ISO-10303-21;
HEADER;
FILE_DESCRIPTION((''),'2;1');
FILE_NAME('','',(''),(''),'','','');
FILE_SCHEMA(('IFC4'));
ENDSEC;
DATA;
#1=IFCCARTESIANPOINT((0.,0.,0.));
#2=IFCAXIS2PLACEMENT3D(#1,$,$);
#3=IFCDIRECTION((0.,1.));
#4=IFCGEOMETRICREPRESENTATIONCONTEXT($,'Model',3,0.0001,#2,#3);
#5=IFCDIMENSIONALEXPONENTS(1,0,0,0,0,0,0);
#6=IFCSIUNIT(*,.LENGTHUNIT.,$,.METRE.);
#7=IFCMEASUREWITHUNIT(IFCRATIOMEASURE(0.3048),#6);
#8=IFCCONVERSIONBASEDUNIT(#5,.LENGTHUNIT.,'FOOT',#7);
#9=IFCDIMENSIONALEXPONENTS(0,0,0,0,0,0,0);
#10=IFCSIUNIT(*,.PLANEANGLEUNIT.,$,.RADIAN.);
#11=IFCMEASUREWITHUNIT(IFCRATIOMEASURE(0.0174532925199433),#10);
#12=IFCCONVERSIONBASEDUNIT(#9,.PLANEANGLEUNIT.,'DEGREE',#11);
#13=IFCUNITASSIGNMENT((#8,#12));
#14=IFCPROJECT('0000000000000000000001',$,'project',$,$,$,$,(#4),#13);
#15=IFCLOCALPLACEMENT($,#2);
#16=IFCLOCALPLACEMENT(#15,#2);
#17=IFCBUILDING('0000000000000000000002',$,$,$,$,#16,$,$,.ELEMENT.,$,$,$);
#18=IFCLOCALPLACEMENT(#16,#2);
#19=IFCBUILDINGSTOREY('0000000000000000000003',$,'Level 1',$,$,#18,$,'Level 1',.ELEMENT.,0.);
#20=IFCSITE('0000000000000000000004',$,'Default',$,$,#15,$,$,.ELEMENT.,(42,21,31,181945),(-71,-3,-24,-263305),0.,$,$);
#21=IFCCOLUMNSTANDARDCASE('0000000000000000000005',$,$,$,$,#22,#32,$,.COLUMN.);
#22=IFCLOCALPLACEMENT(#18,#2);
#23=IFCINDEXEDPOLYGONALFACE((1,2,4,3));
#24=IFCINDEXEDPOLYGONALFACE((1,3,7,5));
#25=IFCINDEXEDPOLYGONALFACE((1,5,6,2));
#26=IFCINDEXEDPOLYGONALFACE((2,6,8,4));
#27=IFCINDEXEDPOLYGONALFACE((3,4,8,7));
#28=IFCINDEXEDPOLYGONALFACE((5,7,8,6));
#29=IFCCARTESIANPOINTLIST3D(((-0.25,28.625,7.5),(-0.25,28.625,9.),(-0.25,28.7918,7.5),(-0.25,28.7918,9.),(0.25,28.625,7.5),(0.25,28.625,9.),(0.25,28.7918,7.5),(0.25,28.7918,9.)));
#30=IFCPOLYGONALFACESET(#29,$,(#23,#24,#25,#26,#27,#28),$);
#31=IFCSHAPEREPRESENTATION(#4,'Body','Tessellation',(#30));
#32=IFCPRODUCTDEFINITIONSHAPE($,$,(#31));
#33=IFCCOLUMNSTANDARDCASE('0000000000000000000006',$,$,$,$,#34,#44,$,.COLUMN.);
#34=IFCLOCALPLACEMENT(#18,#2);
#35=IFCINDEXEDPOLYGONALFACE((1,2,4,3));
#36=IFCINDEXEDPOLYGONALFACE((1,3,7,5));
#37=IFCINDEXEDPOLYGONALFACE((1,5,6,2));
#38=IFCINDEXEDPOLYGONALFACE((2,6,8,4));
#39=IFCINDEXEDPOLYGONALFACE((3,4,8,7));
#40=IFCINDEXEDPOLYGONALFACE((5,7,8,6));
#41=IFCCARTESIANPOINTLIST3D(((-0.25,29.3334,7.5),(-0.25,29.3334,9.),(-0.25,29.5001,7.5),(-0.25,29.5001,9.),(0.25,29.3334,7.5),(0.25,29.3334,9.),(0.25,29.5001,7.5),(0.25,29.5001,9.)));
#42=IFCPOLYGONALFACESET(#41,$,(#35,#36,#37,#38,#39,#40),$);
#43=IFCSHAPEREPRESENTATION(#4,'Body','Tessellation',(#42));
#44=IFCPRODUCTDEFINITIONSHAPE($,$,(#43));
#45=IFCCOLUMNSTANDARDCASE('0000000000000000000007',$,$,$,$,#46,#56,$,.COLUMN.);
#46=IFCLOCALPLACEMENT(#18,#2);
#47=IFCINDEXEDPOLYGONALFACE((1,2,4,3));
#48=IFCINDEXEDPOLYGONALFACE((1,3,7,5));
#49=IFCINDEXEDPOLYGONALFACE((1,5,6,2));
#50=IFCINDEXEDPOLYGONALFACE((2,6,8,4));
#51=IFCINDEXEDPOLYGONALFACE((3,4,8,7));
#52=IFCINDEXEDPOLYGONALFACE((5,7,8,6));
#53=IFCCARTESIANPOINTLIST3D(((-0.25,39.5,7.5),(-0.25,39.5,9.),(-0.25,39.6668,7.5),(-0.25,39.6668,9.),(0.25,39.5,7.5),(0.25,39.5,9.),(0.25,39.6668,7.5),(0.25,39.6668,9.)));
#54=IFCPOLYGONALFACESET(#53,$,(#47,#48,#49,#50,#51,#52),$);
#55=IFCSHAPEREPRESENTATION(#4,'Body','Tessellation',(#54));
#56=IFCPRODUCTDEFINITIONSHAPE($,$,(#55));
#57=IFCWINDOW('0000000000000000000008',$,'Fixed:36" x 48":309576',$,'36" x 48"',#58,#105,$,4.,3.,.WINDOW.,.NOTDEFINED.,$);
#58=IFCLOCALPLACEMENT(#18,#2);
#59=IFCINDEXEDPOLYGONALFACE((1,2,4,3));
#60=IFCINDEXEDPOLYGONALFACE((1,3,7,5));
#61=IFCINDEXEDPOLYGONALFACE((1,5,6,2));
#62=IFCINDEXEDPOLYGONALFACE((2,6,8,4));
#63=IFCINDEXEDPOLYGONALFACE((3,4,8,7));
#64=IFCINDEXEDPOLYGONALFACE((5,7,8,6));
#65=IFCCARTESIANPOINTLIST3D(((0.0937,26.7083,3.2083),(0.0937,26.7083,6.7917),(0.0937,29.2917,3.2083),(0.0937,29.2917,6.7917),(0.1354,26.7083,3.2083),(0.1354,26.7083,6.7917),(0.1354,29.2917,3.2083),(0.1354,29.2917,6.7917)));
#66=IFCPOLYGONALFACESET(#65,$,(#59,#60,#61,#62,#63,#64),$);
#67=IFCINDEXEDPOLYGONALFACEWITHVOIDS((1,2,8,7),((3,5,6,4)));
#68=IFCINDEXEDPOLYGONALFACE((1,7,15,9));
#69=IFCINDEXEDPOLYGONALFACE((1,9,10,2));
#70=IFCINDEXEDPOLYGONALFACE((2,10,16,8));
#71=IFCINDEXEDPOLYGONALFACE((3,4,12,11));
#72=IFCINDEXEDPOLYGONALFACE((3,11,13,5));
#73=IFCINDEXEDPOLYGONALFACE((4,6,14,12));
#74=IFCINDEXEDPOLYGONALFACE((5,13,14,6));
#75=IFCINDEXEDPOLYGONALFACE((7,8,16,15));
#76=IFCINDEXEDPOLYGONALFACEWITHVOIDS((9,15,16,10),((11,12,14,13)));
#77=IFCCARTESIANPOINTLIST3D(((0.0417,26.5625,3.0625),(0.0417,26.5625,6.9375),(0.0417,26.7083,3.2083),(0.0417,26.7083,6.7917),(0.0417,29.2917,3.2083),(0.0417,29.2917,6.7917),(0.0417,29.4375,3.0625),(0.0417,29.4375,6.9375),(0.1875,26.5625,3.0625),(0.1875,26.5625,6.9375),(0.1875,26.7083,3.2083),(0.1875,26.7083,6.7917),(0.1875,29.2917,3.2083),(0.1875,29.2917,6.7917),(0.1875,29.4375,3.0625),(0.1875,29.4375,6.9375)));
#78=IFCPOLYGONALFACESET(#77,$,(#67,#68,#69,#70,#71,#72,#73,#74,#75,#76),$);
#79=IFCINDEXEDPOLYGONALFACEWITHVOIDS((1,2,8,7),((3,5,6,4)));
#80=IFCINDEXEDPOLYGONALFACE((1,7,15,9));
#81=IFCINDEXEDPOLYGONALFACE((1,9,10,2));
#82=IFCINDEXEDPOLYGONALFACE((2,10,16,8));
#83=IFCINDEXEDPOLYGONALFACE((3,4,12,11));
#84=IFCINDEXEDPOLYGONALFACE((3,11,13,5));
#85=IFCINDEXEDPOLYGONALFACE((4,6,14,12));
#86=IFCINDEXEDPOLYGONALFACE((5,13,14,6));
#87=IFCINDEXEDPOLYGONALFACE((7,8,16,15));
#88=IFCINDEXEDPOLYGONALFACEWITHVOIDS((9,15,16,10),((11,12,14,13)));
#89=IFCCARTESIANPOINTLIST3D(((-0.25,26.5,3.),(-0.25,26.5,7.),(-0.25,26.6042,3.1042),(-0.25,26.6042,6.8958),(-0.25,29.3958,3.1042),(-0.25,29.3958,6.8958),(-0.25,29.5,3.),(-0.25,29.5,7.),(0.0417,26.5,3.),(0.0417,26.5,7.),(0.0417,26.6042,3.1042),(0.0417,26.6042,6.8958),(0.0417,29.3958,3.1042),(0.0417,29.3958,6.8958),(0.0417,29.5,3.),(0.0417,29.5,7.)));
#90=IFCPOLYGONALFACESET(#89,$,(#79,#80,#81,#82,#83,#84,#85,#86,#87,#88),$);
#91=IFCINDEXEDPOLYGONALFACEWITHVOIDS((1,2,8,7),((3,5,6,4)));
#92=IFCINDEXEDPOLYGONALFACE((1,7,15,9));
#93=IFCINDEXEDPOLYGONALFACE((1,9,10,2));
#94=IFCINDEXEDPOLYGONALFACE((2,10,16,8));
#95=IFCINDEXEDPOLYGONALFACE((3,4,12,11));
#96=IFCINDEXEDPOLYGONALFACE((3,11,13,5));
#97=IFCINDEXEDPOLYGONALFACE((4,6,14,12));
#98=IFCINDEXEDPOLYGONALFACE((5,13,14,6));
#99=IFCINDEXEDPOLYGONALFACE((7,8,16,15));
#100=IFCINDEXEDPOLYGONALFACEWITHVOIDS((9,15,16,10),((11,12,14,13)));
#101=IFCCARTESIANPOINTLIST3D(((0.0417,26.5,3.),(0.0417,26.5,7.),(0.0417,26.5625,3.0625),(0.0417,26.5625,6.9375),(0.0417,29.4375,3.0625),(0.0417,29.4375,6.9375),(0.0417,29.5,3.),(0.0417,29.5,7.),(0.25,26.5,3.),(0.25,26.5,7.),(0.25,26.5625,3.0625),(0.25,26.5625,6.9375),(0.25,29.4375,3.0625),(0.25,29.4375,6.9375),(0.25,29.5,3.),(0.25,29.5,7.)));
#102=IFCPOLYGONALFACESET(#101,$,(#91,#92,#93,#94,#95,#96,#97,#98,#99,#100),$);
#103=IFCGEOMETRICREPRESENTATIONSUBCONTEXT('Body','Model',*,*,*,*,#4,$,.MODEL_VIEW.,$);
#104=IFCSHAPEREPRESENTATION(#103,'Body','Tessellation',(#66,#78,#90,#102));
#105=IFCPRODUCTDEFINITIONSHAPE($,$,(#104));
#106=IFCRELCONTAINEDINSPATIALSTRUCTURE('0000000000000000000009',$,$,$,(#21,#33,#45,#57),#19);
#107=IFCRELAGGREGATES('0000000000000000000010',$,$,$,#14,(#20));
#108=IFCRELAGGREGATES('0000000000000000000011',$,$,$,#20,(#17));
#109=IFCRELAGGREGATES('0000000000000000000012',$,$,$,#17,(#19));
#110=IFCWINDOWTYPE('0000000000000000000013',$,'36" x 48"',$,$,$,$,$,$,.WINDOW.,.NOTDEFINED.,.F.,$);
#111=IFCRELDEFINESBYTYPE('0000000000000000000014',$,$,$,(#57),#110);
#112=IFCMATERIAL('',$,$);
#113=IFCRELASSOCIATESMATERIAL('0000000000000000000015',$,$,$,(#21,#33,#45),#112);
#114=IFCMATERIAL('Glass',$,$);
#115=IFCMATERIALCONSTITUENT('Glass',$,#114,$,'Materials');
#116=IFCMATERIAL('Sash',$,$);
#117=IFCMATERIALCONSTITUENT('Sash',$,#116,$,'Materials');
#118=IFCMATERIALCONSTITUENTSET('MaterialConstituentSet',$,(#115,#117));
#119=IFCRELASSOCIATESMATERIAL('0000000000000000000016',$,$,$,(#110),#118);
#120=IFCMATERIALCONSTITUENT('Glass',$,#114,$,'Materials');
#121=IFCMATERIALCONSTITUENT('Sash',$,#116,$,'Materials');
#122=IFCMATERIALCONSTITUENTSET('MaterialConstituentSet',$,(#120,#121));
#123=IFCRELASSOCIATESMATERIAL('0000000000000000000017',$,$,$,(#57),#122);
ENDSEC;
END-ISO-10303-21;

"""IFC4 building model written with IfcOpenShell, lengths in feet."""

from ifc_helpers import new_model, entity, si_unit, converted_unit, direction, frame, frame_2d, origin, place, context, subcontext, project, spatial, polyline, rectangle, outline, extrude, source, transform, mapped, material, constituent, constituent_set, type_object, type_shapes, element, save


model = new_model("IFC4")

# Units and contexts
model_context = context("Model", 3, precision=0.0001, world=origin(), true_north=direction((0.0, 1.0)))
body_context = subcontext(model_context, "Body", "Model", "MODEL_VIEW")
ifc_project = project(units=[converted_unit("LENGTHUNIT", "FOOT", entity("IfcRatioMeasure", 0.3048), si_unit("LENGTHUNIT", "METRE"), dimensions=[1, 0, 0, 0, 0, 0, 0]), converted_unit("PLANEANGLEUNIT", "DEGREE", entity("IfcRatioMeasure", 0.0174532925199433), si_unit("PLANEANGLEUNIT", "RADIAN"), dimensions=[0, 0, 0, 0, 0, 0, 0])], contexts=[model_context])

# Site, building, storey
site_placement = place(None, origin())
site = spatial("IfcSite", under=ifc_project, at=site_placement, Name="Default", CompositionType="ELEMENT", RefLatitude=(42, 21, 31, 181945), RefLongitude=(-71, -3, -24, -263305), RefElevation=0.0)
building_placement = place(site_placement, origin())
building = spatial("IfcBuilding", under=site, at=building_placement, CompositionType="ELEMENT")
storey_placement = place(building_placement, origin())
storey = spatial("IfcBuildingStorey", under=building, at=storey_placement, Name="Level 1", LongName="Level 1", CompositionType="ELEMENT", Elevation=0.0)

# Columns
placement_1 = place(storey_placement, frame((0.0, -0.25, 0.0), z_axis=(0.0, 0.0, 1.0), x_axis=(0.0, 1.0, 0.0)))
ifc_material_1 = material(Name="")
for number, where, z_axis, x_axis in (
    (1, (28.9584, 0.0, 7.5), (0.0, 0.0, 1.0), (1.0, 0.0, 0.0)),
    (2, (29.6667, 0.0, 7.5), (0.0, 0.0, 1.0), (1.0, 0.0, 0.0)),
    (3, (39.8334, 0.0, 7.5), (0.0, 0.0, 1.0), (1.0, 0.0, 0.0)),
):
    element("IfcColumnStandardCase", number, at=place(placement_1, frame(where, z_axis=z_axis, x_axis=x_axis)), inside=storey, material=ifc_material_1, PredefinedType="COLUMN", context=model_context, shape_type="SweptSolid", body=[
        extrude(rectangle(XDim=0.1667, YDim=0.5), origin(), (0.0, 0.0, 1.0), 1.5),
    ])

# Window
ifc_material_2 = material(Name="Glass")
ifc_constituent_1 = constituent(ifc_material_2, Name="Glass", Category="Materials")
ifc_material_3 = material(Name="Sash")
ifc_constituent_2 = constituent(ifc_material_3, Name="Sash", Category="Materials")
ifc_constituent_set_1 = constituent_set(constituents=[ifc_constituent_1, ifc_constituent_2], Name="MaterialConstituentSet")
ifc_constituent_3 = constituent(ifc_material_2, Name="Glass", Category="Materials")
ifc_constituent_4 = constituent(ifc_material_3, Name="Sash", Category="Materials")
ifc_constituent_set_2 = constituent_set(constituents=[ifc_constituent_3, ifc_constituent_4], Name="MaterialConstituentSet")
window_type = type_object("IfcWindowType", Name="36\" x 48\"", ParameterTakesPrecedence=False, PartitioningType="NOTDEFINED", PredefinedType="WINDOW", material=ifc_constituent_set_2)
shared_shape = source(origin(), body_context, "Body", "SweptSolid", [
    extrude(rectangle(XDim=0.0417, YDim=2.5833, at=frame_2d((0.0, 0.0), x_axis=(1.0, 0.0))), frame((1.5, 0.3646, 0.2083), z_axis=(0.0, 0.0, 1.0), x_axis=(0.0, 1.0, 0.0)), (0.0, 0.0, 1.0), 3.5833),
    extrude(outline(polyline([(-1.4375, -1.9375), (1.4375, -1.9375), (1.4375, 1.9375), (-1.4375, 1.9375), (-1.4375, -1.9375)]), holes=[polyline([(-1.2917, -1.7917), (-1.2917, 1.7917), (1.2917, 1.7917), (1.2917, -1.7917), (-1.2917, -1.7917)])]), frame((1.5, 0.2917, 2.0), z_axis=(0.0, 1.0, 0.0), x_axis=(1.0, 0.0, 0.0)), (0.0, 0.0, 1.0), 0.1458),
    extrude(outline(polyline([(-1.5, -2.0), (1.5, -2.0), (1.5, 2.0), (-1.5, 2.0), (-1.5, -2.0)]), holes=[polyline([(-1.3958, -1.8958), (-1.3958, 1.8958), (1.3958, 1.8958), (1.3958, -1.8958), (-1.3958, -1.8958)])]), frame((1.5, 0.0, 2.0), z_axis=(0.0, 1.0, 0.0), x_axis=(1.0, 0.0, 0.0)), (0.0, 0.0, 1.0), 0.2917),
    extrude(outline(polyline([(-2.0, -1.5), (2.0, -1.5), (2.0, 1.5), (-2.0, 1.5), (-2.0, -1.5)]), holes=[polyline([(-1.9375, -1.4375), (-1.9375, 1.4375), (1.9375, 1.4375), (1.9375, -1.4375), (-1.9375, -1.4375)])]), frame((1.5, 0.2917, 2.0), z_axis=(0.0, 1.0, 0.0), x_axis=(0.0, 0.0, -1.0)), (0.0, 0.0, 1.0), 0.2083),
])
type_shapes(window_type, [shared_shape])
placement_2 = place(placement_1, frame((29.75, 0.25, 3.0)))
window_placement = place(placement_2, frame((0.0, 0.0, 0.0), z_axis=(0.0, 0.0, 1.0), x_axis=(-1.0, 0.0, 0.0)))
element("IfcWindow", 4, at=window_placement, inside=storey, type_object=window_type, material=ifc_constituent_set_1, Name="Fixed:36\" x 48\":309576", ObjectType="36\" x 48\"", OverallHeight=4.0, OverallWidth=3.0, PartitioningType="NOTDEFINED", PredefinedType="WINDOW", context=body_context, shape_type="MappedRepresentation", body=[
    mapped(shared_shape, transform((0.0, 0.0, 0.0), scale=1.0)),
])

save(model, "model.ifc")
